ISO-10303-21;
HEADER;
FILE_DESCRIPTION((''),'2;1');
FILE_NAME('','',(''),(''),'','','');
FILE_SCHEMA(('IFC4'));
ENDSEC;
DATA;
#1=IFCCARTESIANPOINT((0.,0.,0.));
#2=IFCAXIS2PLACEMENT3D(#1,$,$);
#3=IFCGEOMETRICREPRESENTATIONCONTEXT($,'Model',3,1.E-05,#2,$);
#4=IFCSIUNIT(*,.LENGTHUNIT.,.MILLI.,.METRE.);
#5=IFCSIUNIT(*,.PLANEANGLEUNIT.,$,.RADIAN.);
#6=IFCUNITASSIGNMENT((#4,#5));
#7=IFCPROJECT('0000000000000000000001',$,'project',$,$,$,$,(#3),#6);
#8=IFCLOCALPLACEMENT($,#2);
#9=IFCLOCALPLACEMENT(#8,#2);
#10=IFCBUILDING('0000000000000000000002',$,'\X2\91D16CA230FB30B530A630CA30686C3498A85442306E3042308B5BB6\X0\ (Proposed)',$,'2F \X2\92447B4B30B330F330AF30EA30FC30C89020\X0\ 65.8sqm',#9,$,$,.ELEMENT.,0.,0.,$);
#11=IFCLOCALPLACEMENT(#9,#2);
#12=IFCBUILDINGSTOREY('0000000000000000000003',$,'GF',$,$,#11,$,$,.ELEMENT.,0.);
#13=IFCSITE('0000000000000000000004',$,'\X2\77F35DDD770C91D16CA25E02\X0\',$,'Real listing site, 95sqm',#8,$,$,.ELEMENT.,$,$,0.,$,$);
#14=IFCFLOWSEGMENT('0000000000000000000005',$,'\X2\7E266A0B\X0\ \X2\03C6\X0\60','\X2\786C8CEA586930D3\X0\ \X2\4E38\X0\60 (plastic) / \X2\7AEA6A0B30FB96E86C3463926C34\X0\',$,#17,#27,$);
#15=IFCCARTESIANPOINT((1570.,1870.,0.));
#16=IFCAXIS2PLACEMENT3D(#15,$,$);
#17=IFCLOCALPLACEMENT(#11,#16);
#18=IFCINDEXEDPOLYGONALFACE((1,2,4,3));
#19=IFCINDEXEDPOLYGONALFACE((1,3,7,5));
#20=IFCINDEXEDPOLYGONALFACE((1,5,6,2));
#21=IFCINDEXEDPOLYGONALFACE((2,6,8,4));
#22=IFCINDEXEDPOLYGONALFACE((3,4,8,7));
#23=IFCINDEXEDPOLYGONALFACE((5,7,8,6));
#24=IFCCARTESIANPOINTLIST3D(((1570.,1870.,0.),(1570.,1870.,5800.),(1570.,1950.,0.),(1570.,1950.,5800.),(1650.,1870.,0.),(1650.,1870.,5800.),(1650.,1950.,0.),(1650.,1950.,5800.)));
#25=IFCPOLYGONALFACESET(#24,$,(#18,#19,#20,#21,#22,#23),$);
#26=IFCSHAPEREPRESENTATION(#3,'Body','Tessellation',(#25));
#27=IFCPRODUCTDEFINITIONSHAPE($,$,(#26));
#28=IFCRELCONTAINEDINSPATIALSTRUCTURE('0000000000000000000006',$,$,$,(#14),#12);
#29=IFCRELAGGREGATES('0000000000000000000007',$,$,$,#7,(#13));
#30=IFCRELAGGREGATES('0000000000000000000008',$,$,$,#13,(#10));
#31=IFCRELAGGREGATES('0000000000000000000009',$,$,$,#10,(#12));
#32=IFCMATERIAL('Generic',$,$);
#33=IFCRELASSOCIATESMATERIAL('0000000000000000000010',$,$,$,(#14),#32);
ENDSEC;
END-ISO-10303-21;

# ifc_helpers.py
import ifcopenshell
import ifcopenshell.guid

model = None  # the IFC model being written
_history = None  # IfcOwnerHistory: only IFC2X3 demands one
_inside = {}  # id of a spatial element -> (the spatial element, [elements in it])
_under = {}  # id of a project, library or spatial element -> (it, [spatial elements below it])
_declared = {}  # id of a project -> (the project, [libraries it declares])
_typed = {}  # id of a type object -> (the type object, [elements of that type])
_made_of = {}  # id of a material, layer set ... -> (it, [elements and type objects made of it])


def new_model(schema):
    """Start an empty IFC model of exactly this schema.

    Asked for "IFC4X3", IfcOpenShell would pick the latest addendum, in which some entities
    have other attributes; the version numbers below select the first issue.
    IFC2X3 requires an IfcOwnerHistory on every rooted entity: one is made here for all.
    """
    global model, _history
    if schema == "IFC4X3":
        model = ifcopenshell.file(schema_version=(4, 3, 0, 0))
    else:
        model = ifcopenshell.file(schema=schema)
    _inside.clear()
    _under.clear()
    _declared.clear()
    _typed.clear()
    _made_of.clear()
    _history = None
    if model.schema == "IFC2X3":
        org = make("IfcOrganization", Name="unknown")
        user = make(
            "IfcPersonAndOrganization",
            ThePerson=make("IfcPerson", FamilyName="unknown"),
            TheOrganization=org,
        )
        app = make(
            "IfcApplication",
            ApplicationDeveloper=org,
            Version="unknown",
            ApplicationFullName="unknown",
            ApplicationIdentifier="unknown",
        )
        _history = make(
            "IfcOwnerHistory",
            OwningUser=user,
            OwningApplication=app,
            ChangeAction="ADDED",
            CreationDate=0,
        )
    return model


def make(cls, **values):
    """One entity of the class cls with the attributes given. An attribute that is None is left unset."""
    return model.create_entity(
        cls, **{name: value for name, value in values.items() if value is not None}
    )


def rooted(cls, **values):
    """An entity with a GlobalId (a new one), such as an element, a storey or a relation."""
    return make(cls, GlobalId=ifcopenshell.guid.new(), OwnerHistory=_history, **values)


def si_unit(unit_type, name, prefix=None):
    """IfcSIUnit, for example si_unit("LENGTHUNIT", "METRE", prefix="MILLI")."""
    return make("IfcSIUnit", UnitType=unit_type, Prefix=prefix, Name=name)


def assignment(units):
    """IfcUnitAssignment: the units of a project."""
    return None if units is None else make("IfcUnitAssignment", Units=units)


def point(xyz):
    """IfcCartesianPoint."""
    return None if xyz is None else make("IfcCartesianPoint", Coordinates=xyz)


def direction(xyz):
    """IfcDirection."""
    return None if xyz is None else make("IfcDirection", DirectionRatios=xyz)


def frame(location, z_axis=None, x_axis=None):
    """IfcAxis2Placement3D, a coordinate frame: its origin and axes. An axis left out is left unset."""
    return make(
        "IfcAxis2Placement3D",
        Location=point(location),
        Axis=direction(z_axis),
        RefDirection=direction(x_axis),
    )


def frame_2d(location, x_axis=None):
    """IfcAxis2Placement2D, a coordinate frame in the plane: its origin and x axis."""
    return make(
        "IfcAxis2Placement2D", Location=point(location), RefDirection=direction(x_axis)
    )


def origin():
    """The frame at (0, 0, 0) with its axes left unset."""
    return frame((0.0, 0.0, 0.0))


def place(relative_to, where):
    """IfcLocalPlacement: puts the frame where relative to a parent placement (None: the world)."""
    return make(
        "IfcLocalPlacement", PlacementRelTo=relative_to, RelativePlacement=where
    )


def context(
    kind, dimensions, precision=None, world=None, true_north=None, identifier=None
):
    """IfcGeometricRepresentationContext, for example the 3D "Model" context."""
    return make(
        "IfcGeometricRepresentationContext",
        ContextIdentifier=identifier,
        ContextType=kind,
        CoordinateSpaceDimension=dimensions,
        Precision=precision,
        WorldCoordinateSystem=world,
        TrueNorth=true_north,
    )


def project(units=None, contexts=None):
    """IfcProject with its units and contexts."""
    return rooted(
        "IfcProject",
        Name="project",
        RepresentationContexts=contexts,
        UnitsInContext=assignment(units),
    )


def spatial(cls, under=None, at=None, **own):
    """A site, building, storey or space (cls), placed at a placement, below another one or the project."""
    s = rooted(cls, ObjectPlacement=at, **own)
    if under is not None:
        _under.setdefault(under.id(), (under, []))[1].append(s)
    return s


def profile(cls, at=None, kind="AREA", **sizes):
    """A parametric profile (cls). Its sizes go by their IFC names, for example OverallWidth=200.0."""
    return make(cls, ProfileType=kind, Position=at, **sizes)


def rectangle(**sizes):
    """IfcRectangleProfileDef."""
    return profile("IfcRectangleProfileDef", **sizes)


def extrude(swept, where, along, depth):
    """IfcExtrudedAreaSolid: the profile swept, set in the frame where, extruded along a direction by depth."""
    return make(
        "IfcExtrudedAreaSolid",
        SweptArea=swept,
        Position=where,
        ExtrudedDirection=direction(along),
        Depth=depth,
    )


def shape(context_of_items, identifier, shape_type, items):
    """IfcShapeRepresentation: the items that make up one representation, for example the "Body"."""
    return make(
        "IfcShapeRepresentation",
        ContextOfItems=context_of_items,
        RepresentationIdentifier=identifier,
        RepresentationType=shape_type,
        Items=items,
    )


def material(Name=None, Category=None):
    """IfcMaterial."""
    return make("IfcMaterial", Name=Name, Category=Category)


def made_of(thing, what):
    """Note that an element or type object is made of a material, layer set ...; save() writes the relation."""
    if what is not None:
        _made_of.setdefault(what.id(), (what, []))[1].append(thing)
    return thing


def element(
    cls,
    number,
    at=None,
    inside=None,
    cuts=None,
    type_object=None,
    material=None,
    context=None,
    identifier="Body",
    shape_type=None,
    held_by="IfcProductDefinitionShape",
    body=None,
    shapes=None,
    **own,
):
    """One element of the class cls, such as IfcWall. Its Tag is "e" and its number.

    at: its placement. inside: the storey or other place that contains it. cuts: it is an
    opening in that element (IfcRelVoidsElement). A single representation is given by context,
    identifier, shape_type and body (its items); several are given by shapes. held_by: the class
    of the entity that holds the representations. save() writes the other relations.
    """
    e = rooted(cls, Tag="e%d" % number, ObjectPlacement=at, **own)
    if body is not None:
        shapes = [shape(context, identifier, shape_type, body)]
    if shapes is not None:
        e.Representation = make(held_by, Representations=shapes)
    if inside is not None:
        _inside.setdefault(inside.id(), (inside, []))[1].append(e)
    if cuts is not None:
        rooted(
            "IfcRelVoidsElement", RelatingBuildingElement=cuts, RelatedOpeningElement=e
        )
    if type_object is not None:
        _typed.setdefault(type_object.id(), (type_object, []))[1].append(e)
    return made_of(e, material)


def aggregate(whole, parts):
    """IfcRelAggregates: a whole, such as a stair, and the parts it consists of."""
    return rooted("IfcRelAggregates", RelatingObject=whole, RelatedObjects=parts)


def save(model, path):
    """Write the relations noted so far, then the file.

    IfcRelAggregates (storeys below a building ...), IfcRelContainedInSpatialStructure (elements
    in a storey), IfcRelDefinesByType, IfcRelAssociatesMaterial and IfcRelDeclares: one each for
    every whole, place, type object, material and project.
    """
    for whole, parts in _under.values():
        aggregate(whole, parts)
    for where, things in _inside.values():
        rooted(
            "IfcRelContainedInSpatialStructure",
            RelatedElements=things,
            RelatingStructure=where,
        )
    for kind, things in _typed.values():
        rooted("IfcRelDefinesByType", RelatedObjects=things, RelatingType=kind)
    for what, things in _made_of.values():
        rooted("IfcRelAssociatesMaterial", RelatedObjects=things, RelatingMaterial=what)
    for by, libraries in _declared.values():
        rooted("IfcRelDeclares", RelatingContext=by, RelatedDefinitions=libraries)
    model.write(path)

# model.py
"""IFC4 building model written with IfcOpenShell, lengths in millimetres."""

from ifc_helpers import new_model, si_unit, frame, frame_2d, origin, place, context, project, spatial, rectangle, extrude, material, element, save


model = new_model("IFC4")

# Units and contexts
model_context = context("Model", 3, precision=1e-05, world=origin())
ifc_project = project(units=[si_unit("LENGTHUNIT", "METRE", prefix="MILLI"), si_unit("PLANEANGLEUNIT", "RADIAN")], contexts=[model_context])

# Site, building, storey
site_placement = place(None, origin())
site = spatial("IfcSite", under=ifc_project, at=site_placement, Name="石川県金沢市", ObjectType="Real listing site, 95sqm", CompositionType="ELEMENT", RefElevation=0.0)
building_placement = place(site_placement, origin())
building = spatial("IfcBuilding", under=site, at=building_placement, Name="金沢・サウナと水風呂のある家 (Proposed)", ObjectType="2F 鉄筋コンクリート造 65.8sqm", CompositionType="ELEMENT", ElevationOfRefHeight=0.0, ElevationOfTerrain=0.0)
storey_placement = place(building_placement, origin())
storey = spatial("IfcBuildingStorey", under=building, at=storey_placement, Name="GF", CompositionType="ELEMENT", Elevation=0.0)

# Shared definitions
ifc_material_1 = material(Name="Generic")

# Flow segment
flow_segment_1_placement = place(storey_placement, frame((1570.0, 1870.0, 0.0)))
element("IfcFlowSegment", 1, at=flow_segment_1_placement, inside=storey, material=ifc_material_1, Name="縦樋 φ60", Description="硬質塩ビ 丸60 (plastic) / 竪樋・雨水排水", context=model_context, shape_type="SweptSolid", body=[
    extrude(rectangle(XDim=80.0, YDim=80.0, at=frame_2d((40.0, 40.0))), frame((1570.0, 1870.0, 0.0)), (0.0, 0.0, 1.0), 5800.0),
])

save(model, "model.ifc")
